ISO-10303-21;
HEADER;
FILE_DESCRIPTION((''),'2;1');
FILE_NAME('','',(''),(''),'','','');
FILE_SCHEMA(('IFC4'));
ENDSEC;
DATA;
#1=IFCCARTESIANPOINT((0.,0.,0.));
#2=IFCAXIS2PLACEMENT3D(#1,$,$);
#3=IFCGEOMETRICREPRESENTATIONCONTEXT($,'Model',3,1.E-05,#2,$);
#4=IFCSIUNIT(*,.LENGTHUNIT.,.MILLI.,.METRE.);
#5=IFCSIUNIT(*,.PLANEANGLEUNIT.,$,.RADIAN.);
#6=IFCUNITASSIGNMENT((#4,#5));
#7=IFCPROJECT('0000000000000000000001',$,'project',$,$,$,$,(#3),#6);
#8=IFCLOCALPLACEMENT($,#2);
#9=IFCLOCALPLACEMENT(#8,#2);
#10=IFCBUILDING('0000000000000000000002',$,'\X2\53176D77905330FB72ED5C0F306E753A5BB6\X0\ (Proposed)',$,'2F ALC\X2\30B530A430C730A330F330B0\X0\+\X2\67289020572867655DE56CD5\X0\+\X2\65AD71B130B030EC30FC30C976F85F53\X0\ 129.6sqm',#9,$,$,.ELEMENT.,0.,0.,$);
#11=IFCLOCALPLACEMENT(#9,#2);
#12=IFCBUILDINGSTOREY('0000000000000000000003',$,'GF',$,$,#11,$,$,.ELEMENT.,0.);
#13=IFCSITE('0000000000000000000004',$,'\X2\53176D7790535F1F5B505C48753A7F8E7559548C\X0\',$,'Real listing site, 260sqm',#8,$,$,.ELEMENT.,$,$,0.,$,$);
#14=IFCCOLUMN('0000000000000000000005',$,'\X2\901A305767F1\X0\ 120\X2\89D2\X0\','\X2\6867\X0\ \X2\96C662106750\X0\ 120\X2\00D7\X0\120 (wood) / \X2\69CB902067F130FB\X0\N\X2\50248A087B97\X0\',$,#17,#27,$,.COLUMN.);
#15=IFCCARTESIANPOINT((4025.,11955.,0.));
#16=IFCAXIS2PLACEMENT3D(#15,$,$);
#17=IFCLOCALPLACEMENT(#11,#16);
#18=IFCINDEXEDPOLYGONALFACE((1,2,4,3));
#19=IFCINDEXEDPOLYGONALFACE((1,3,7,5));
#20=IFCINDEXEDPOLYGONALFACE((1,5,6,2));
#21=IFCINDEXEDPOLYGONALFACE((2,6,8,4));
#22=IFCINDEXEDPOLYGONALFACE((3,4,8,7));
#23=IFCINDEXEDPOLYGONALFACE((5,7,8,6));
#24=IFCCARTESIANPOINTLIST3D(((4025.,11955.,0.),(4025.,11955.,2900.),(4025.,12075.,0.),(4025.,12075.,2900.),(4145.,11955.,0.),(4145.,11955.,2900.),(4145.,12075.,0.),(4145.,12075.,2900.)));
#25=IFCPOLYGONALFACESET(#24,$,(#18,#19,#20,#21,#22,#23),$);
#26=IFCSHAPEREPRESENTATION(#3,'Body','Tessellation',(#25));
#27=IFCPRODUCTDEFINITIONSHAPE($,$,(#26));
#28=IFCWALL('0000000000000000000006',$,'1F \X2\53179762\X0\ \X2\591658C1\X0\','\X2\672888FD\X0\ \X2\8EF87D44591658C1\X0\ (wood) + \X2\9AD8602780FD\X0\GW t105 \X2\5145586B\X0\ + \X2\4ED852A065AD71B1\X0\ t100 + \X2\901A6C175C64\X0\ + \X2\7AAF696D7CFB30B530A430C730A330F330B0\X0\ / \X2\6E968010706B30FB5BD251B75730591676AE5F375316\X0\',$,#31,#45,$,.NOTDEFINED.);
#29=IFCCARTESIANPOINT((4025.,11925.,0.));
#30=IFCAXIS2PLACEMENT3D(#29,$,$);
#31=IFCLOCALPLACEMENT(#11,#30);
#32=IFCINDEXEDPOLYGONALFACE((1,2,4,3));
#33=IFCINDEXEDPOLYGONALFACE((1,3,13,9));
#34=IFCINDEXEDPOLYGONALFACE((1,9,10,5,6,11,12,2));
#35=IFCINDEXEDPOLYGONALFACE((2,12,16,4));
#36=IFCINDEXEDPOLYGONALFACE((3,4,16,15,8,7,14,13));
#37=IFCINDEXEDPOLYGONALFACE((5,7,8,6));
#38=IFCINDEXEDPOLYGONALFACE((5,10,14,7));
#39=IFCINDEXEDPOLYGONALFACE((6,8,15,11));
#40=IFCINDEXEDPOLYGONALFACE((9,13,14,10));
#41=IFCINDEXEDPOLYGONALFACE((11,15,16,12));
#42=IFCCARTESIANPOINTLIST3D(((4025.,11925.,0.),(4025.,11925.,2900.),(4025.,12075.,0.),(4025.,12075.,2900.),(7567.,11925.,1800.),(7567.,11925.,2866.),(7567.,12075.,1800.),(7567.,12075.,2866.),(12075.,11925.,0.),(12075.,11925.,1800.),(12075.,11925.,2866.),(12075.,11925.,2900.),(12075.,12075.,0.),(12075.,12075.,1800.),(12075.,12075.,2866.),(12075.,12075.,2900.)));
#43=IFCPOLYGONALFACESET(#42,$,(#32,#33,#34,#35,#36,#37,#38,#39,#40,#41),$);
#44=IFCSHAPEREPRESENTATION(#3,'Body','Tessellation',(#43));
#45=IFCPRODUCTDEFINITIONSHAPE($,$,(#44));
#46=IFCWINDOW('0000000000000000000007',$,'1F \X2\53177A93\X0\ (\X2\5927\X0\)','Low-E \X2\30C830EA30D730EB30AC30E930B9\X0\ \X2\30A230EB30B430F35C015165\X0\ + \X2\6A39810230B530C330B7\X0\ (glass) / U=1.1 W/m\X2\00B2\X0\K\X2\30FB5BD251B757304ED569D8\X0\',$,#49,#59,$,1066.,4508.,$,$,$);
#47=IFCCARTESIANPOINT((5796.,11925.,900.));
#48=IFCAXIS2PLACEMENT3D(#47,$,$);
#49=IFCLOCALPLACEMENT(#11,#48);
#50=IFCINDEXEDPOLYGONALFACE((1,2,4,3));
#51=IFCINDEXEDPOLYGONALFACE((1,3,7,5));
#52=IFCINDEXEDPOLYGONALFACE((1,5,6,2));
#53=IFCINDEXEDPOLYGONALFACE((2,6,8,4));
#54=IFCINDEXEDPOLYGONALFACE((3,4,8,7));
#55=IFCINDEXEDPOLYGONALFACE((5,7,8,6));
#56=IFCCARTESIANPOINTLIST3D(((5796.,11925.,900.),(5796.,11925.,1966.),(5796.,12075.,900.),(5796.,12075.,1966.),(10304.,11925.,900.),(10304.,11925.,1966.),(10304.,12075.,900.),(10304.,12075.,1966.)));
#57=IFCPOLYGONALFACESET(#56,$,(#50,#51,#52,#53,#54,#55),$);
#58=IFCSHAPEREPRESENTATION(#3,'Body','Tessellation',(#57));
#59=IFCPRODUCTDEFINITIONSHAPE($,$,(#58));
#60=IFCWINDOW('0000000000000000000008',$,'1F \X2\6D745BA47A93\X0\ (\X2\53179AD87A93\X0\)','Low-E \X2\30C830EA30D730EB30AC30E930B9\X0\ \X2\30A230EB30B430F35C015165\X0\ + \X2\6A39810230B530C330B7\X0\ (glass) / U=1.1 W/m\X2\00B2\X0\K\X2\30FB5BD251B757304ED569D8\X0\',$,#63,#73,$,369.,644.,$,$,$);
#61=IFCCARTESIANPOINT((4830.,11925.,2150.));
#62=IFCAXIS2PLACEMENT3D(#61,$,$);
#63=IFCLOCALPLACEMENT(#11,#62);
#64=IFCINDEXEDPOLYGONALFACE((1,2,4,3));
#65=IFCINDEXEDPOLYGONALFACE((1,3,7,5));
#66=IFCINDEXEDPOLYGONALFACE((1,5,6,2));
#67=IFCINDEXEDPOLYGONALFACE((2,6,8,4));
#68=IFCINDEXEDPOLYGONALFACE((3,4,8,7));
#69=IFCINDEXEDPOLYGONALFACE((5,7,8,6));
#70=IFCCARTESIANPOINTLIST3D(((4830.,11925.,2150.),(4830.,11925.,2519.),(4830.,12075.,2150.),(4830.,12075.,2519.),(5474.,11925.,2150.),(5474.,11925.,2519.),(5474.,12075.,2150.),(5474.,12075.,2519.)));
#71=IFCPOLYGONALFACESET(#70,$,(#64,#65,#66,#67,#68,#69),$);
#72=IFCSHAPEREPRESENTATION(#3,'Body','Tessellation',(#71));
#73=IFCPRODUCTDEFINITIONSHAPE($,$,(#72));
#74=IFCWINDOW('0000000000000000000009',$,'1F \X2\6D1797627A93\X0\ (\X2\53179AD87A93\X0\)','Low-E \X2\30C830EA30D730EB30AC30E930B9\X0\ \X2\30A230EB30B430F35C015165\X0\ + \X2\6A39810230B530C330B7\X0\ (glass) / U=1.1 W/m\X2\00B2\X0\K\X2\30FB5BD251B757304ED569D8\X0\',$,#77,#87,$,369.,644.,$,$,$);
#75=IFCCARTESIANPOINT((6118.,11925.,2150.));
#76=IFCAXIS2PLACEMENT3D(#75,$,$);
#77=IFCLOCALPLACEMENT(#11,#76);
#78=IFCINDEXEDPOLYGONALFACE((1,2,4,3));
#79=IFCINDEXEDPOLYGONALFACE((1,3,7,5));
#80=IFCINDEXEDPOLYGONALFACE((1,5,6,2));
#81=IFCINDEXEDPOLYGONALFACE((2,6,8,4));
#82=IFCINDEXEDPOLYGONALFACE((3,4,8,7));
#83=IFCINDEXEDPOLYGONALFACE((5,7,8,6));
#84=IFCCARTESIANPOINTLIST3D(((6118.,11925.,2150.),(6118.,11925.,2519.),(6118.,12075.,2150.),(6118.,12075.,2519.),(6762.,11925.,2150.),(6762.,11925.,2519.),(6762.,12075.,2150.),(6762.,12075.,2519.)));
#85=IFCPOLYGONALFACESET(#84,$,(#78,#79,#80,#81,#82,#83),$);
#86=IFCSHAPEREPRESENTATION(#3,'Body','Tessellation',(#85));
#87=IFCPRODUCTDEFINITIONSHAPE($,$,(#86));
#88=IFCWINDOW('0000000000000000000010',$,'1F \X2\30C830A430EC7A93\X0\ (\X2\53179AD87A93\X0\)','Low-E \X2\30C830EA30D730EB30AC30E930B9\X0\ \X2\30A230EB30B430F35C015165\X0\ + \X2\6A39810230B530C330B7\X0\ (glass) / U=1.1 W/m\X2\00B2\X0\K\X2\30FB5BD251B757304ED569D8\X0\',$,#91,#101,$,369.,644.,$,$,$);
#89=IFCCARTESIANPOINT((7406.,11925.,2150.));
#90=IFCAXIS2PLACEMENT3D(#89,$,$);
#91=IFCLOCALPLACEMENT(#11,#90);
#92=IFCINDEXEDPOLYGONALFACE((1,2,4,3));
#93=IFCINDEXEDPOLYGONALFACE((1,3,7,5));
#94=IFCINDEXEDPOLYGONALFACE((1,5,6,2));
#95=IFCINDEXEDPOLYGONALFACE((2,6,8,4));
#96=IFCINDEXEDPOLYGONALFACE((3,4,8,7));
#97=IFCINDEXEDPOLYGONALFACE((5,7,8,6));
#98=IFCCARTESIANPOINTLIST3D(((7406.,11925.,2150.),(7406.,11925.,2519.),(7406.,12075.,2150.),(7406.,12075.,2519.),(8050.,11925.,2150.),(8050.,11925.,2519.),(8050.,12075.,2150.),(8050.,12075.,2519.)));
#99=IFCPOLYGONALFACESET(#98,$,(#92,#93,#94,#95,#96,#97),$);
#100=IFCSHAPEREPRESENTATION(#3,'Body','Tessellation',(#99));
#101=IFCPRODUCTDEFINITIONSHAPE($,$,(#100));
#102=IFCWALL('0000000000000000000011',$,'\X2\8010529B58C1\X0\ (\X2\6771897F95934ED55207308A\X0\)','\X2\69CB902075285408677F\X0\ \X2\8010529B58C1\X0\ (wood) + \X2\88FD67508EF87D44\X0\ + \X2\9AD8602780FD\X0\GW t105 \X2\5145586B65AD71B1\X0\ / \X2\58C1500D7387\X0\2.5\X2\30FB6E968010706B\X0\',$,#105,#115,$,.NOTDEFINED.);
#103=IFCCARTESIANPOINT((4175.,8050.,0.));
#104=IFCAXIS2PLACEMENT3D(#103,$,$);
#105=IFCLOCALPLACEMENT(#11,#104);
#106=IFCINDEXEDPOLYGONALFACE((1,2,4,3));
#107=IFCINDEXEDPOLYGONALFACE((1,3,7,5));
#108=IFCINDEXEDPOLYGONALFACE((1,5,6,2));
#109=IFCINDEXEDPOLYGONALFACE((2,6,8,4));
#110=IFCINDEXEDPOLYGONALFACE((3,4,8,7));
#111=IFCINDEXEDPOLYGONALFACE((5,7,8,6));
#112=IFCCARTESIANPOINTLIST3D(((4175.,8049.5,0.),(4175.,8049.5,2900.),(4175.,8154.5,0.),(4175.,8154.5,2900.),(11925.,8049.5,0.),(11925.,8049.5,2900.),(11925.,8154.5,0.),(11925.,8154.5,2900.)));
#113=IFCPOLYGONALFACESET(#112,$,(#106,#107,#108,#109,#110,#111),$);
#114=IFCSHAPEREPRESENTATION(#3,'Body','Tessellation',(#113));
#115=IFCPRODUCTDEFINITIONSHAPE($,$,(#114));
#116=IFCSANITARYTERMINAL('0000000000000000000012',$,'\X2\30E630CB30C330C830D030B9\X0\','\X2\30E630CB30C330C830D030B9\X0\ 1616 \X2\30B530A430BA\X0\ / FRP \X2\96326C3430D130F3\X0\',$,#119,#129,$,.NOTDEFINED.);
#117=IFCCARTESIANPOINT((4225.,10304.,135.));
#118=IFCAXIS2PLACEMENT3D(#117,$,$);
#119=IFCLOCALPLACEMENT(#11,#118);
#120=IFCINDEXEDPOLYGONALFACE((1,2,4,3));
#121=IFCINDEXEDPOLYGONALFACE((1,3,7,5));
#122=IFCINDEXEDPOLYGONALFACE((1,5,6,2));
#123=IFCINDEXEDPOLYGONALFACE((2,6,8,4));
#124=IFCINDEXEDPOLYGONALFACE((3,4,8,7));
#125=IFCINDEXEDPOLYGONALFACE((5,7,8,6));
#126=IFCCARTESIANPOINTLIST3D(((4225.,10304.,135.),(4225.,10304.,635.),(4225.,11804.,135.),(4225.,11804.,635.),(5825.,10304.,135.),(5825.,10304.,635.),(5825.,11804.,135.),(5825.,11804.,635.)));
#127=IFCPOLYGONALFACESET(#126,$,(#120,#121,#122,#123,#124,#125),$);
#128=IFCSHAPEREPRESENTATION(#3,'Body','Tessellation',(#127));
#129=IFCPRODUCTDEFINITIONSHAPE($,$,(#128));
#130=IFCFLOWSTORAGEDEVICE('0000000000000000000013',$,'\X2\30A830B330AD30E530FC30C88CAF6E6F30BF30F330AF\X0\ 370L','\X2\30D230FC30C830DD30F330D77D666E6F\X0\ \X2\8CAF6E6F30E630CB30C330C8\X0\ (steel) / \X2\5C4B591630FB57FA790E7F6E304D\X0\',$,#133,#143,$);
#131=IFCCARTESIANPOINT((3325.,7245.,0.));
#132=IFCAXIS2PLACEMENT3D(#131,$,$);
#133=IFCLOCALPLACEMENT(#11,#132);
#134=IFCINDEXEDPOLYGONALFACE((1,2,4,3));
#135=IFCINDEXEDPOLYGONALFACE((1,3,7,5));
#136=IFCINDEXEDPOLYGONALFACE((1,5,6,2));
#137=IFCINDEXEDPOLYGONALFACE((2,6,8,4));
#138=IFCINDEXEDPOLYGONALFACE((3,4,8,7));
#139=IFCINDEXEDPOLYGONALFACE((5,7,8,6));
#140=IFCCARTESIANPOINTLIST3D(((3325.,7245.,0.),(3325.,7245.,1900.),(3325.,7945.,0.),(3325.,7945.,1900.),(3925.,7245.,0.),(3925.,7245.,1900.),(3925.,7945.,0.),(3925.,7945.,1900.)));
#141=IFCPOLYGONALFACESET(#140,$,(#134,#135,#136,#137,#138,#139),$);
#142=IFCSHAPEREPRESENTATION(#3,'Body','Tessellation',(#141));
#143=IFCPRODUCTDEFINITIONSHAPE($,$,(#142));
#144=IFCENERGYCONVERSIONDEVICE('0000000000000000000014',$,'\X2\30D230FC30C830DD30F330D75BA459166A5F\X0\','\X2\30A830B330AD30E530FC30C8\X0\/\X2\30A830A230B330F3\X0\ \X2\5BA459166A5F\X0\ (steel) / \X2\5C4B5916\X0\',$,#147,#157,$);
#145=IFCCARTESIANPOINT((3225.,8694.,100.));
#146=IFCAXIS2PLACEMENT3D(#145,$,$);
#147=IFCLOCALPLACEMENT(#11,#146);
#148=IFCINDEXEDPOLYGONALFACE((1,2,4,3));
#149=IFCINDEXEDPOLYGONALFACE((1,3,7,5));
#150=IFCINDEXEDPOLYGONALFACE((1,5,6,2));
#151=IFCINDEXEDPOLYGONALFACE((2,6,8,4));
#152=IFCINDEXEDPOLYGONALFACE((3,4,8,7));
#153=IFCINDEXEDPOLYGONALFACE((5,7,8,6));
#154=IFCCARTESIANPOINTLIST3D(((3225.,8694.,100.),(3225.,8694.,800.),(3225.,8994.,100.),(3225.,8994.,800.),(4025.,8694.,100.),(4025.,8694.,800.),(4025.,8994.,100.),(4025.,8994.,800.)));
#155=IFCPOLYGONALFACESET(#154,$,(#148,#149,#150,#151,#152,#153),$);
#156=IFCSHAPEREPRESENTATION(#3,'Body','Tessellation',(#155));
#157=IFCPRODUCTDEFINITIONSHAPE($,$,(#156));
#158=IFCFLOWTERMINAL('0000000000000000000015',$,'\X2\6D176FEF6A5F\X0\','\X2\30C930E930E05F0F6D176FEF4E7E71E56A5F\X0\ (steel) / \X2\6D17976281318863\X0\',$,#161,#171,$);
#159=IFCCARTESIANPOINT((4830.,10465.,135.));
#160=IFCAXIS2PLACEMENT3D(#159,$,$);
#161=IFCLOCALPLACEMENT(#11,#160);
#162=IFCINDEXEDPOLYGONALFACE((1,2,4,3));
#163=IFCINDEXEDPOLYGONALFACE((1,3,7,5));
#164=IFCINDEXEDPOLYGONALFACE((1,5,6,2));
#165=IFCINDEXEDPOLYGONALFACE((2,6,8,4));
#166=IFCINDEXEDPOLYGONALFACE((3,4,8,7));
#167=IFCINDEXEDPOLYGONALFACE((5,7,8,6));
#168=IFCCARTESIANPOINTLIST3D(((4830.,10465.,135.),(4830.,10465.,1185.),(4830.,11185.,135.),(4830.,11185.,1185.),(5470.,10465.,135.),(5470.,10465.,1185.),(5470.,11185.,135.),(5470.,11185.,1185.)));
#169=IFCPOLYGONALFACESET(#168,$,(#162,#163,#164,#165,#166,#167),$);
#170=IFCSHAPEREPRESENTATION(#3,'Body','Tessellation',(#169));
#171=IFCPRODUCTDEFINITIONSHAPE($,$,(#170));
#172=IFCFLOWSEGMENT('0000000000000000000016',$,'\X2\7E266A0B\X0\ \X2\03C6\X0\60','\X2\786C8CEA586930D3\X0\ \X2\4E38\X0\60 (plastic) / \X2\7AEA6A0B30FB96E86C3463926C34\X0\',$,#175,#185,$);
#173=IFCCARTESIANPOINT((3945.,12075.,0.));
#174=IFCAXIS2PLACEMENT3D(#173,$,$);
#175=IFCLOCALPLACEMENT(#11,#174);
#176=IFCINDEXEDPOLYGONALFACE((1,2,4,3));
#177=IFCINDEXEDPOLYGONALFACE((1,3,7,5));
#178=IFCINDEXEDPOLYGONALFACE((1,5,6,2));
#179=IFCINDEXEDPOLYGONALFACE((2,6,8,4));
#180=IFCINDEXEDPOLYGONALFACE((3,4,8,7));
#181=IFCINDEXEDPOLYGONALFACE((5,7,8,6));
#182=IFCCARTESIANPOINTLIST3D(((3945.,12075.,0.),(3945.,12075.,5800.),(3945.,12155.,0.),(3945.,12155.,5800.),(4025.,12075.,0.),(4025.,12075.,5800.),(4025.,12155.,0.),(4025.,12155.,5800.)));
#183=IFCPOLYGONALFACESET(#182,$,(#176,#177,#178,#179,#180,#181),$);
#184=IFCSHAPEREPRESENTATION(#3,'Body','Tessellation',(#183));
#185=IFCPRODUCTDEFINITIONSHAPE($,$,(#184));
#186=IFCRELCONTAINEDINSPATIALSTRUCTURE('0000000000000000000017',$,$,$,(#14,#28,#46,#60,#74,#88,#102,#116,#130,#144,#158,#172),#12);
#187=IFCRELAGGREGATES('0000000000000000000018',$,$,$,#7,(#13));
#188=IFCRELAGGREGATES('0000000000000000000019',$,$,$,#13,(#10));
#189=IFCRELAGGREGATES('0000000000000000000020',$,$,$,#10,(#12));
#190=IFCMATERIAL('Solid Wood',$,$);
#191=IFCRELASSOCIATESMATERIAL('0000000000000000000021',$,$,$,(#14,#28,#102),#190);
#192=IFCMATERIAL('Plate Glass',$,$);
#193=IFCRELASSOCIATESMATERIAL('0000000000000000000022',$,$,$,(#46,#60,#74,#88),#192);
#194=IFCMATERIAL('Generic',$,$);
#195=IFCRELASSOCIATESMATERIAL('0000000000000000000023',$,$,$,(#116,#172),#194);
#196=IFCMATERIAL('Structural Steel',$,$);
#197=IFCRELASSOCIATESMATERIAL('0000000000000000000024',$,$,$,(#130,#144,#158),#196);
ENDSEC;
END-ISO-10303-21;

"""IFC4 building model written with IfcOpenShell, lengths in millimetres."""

from ifc_helpers import new_model, si_unit, frame, frame_2d, origin, place, context, project, spatial, rectangle, extrude, material, element, fill, save


model = new_model("IFC4")

# Units and contexts
model_context = context("Model", 3, precision=1e-05, world=origin())
ifc_project = project(units=[si_unit("LENGTHUNIT", "METRE", prefix="MILLI"), si_unit("PLANEANGLEUNIT", "RADIAN")], contexts=[model_context])

# Site, building, storey
site_placement = place(None, origin())
site = spatial("IfcSite", under=ifc_project, at=site_placement, Name="北海道弟子屈町美留和", ObjectType="Real listing site, 260sqm", CompositionType="ELEMENT", RefElevation=0.0)
building_placement = place(site_placement, origin())
building = spatial("IfcBuilding", under=site, at=building_placement, Name="北海道・狭小の町家 (Proposed)", ObjectType="2F ALCサイディング+木造在来工法+断熱グレード相当 129.6sqm", CompositionType="ELEMENT", ElevationOfRefHeight=0.0, ElevationOfTerrain=0.0)
storey_placement = place(building_placement, origin())
storey = spatial("IfcBuildingStorey", under=building, at=storey_placement, Name="GF", CompositionType="ELEMENT", Elevation=0.0)

# Column
ifc_material_1 = material(Name="Solid Wood")
column_1_placement = place(storey_placement, frame((4025.0, 11955.0, 0.0)))
element("IfcColumn", 1, at=column_1_placement, inside=storey, material=ifc_material_1, Name="通し柱 120角", Description="桧 集成材 120×120 (wood) / 構造柱・N値計算", PredefinedType="COLUMN", context=model_context, shape_type="SweptSolid", body=[
    extrude(rectangle(XDim=120.0, YDim=120.0, at=frame_2d((60.0, 60.0))), frame((4025.0, 11955.0, 0.0)), (0.0, 0.0, 1.0), 2900.0),
])

# Wall, openings, windows
wall_1_placement = place(storey_placement, frame((4025.0, 11925.0, 0.0)))
wall_1 = element("IfcWall", 2, at=wall_1_placement, inside=storey, material=ifc_material_1, Name="1F 北面 外壁", Description="木製 軸組外壁 (wood) + 高性能GW t105 充填 + 付加断熱 t100 + 通気層 + 窯業系サイディング / 準耐火・寒冷地外皮強化", PredefinedType="NOTDEFINED", context=model_context, shape_type="SweptSolid", body=[
    extrude(rectangle(XDim=8050.0, YDim=150.0, at=frame_2d((4025.0, 75.0))), frame((4025.0, 11925.0, 0.0)), (0.0, 0.0, 1.0), 2900.0),
])
opening_1_placement = place(storey_placement, frame((5796.0, 11925.0, 900.0)))
opening_1 = element("IfcOpeningElement", 3, at=opening_1_placement, cuts=wall_1, PredefinedType="NOTDEFINED", context=model_context, shape_type="SweptSolid", body=[
    extrude(rectangle(XDim=4508.0, YDim=150.0, at=frame_2d((2254.0, 75.0))), frame((5796.0, 11925.0, 900.0)), (0.0, 0.0, 1.0), 1066.0),
])
opening_2_placement = place(storey_placement, frame((4830.0, 11925.0, 2150.0)))
opening_2 = element("IfcOpeningElement", 4, at=opening_2_placement, cuts=wall_1, PredefinedType="NOTDEFINED", context=model_context, shape_type="SweptSolid", body=[
    extrude(rectangle(XDim=644.0, YDim=150.0, at=frame_2d((322.0, 75.0))), frame((4830.0, 11925.0, 2150.0)), (0.0, 0.0, 1.0), 369.0),
])
opening_3_placement = place(storey_placement, frame((6118.0, 11925.0, 2150.0)))
opening_3 = element("IfcOpeningElement", 5, at=opening_3_placement, cuts=wall_1, PredefinedType="NOTDEFINED", context=model_context, shape_type="SweptSolid", body=[
    extrude(rectangle(XDim=644.0, YDim=150.0, at=frame_2d((322.0, 75.0))), frame((6118.0, 11925.0, 2150.0)), (0.0, 0.0, 1.0), 369.0),
])
opening_4_placement = place(storey_placement, frame((7406.0, 11925.0, 2150.0)))
opening_4 = element("IfcOpeningElement", 6, at=opening_4_placement, cuts=wall_1, PredefinedType="NOTDEFINED", context=model_context, shape_type="SweptSolid", body=[
    extrude(rectangle(XDim=644.0, YDim=150.0, at=frame_2d((322.0, 75.0))), frame((7406.0, 11925.0, 2150.0)), (0.0, 0.0, 1.0), 369.0),
])
ifc_material_2 = material(Name="Plate Glass")
window_1_placement = place(storey_placement, frame((5796.0, 11925.0, 900.0)))
window_1 = element("IfcWindow", 7, at=window_1_placement, inside=storey, material=ifc_material_2, Name="1F 北窓 (大)", Description="Low-E トリプルガラス アルゴン封入 + 樹脂サッシ (glass) / U=1.1 W/m²K・寒冷地仕様", OverallHeight=1066.0, OverallWidth=4508.0, context=model_context, shape_type="SweptSolid", body=[
    extrude(rectangle(XDim=4508.0, YDim=150.0, at=frame_2d((2254.0, 75.0))), frame((5796.0, 11925.0, 900.0)), (0.0, 0.0, 1.0), 1066.0),
])
fill(opening_1, window_1)
window_2_placement = place(storey_placement, frame((4830.0, 11925.0, 2150.0)))
window_2 = element("IfcWindow", 8, at=window_2_placement, inside=storey, material=ifc_material_2, Name="1F 浴室窓 (北高窓)", Description="Low-E トリプルガラス アルゴン封入 + 樹脂サッシ (glass) / U=1.1 W/m²K・寒冷地仕様", OverallHeight=369.0, OverallWidth=644.0, context=model_context, shape_type="SweptSolid", body=[
    extrude(rectangle(XDim=644.0, YDim=150.0, at=frame_2d((322.0, 75.0))), frame((4830.0, 11925.0, 2150.0)), (0.0, 0.0, 1.0), 369.0),
])
fill(opening_2, window_2)
window_3_placement = place(storey_placement, frame((6118.0, 11925.0, 2150.0)))
window_3 = element("IfcWindow", 9, at=window_3_placement, inside=storey, material=ifc_material_2, Name="1F 洗面窓 (北高窓)", Description="Low-E トリプルガラス アルゴン封入 + 樹脂サッシ (glass) / U=1.1 W/m²K・寒冷地仕様", OverallHeight=369.0, OverallWidth=644.0, context=model_context, shape_type="SweptSolid", body=[
    extrude(rectangle(XDim=644.0, YDim=150.0, at=frame_2d((322.0, 75.0))), frame((6118.0, 11925.0, 2150.0)), (0.0, 0.0, 1.0), 369.0),
])
fill(opening_3, window_3)
window_4_placement = place(storey_placement, frame((7406.0, 11925.0, 2150.0)))
window_4 = element("IfcWindow", 10, at=window_4_placement, inside=storey, material=ifc_material_2, Name="1F トイレ窓 (北高窓)", Description="Low-E トリプルガラス アルゴン封入 + 樹脂サッシ (glass) / U=1.1 W/m²K・寒冷地仕様", OverallHeight=369.0, OverallWidth=644.0, context=model_context, shape_type="SweptSolid", body=[
    extrude(rectangle(XDim=644.0, YDim=150.0, at=frame_2d((322.0, 75.0))), frame((7406.0, 11925.0, 2150.0)), (0.0, 0.0, 1.0), 369.0),
])
fill(opening_4, window_4)

# Wall
wall_2_placement = place(storey_placement, frame((4175.0, 8050.0, 0.0)))
element("IfcWall", 11, at=wall_2_placement, inside=storey, material=ifc_material_1, Name="耐力壁 (東西間仕切り)", Description="構造用合板 耐力壁 (wood) + 製材軸組 + 高性能GW t105 充填断熱 / 壁倍率2.5・準耐火", PredefinedType="NOTDEFINED", context=model_context, shape_type="SweptSolid", body=[
    extrude(rectangle(XDim=7750.0, YDim=105.0, at=frame_2d((3875.0, 52.0))), frame((4175.0, 8050.0, 0.0)), (0.0, 0.0, 1.0), 2900.0),
])

# Sanitary terminal
ifc_material_3 = material(Name="Generic")
sanitary_terminal_placement = place(storey_placement, frame((4225.0, 10304.0, 135.0)))
element("IfcSanitaryTerminal", 12, at=sanitary_terminal_placement, inside=storey, material=ifc_material_3, Name="ユニットバス", Description="ユニットバス 1616 サイズ / FRP 防水パン", PredefinedType="NOTDEFINED", context=model_context, shape_type="SweptSolid", body=[
    extrude(rectangle(XDim=1600.0, YDim=1500.0, at=frame_2d((800.0, 750.0))), frame((4225.0, 10304.0, 135.0)), (0.0, 0.0, 1.0), 500.0),
])

# Flow storage device
ifc_material_4 = material(Name="Structural Steel")
flow_storage_device_placement = place(storey_placement, frame((3325.0, 7245.0, 0.0)))
element("IfcFlowStorageDevice", 13, at=flow_storage_device_placement, inside=storey, material=ifc_material_4, Name="エコキュート貯湯タンク 370L", Description="ヒートポンプ給湯 貯湯ユニット (steel) / 屋外・基礎置き", context=model_context, shape_type="SweptSolid", body=[
    extrude(rectangle(XDim=600.0, YDim=700.0, at=frame_2d((300.0, 350.0))), frame((3325.0, 7245.0, 0.0)), (0.0, 0.0, 1.0), 1900.0),
])

# Energy conversion device
energy_conversion_device_placement = place(storey_placement, frame((3225.0, 8694.0, 100.0)))
element("IfcEnergyConversionDevice", 14, at=energy_conversion_device_placement, inside=storey, material=ifc_material_4, Name="ヒートポンプ室外機", Description="エコキュート/エアコン 室外機 (steel) / 屋外", context=model_context, shape_type="SweptSolid", body=[
    extrude(rectangle(XDim=800.0, YDim=300.0, at=frame_2d((400.0, 150.0))), frame((3225.0, 8694.0, 100.0)), (0.0, 0.0, 1.0), 700.0),
])

# Flow terminal
flow_terminal_placement = place(storey_placement, frame((4830.0, 10465.0, 135.0)))
element("IfcFlowTerminal", 15, at=flow_terminal_placement, inside=storey, material=ifc_material_4, Name="洗濯機", Description="ドラム式洗濯乾燥機 (steel) / 洗面脱衣", context=model_context, shape_type="SweptSolid", body=[
    extrude(rectangle(XDim=640.0, YDim=720.0, at=frame_2d((320.0, 360.0))), frame((4830.0, 10465.0, 135.0)), (0.0, 0.0, 1.0), 1050.0),
])

# Flow segment
flow_segment_placement = place(storey_placement, frame((3945.0, 12075.0, 0.0)))
element("IfcFlowSegment", 16, at=flow_segment_placement, inside=storey, material=ifc_material_3, Name="縦樋 φ60", Description="硬質塩ビ 丸60 (plastic) / 竪樋・雨水排水", context=model_context, shape_type="SweptSolid", body=[
    extrude(rectangle(XDim=80.0, YDim=80.0, at=frame_2d((40.0, 40.0))), frame((3945.0, 12075.0, 0.0)), (0.0, 0.0, 1.0), 5800.0),
])

save(model, "model.ifc")
